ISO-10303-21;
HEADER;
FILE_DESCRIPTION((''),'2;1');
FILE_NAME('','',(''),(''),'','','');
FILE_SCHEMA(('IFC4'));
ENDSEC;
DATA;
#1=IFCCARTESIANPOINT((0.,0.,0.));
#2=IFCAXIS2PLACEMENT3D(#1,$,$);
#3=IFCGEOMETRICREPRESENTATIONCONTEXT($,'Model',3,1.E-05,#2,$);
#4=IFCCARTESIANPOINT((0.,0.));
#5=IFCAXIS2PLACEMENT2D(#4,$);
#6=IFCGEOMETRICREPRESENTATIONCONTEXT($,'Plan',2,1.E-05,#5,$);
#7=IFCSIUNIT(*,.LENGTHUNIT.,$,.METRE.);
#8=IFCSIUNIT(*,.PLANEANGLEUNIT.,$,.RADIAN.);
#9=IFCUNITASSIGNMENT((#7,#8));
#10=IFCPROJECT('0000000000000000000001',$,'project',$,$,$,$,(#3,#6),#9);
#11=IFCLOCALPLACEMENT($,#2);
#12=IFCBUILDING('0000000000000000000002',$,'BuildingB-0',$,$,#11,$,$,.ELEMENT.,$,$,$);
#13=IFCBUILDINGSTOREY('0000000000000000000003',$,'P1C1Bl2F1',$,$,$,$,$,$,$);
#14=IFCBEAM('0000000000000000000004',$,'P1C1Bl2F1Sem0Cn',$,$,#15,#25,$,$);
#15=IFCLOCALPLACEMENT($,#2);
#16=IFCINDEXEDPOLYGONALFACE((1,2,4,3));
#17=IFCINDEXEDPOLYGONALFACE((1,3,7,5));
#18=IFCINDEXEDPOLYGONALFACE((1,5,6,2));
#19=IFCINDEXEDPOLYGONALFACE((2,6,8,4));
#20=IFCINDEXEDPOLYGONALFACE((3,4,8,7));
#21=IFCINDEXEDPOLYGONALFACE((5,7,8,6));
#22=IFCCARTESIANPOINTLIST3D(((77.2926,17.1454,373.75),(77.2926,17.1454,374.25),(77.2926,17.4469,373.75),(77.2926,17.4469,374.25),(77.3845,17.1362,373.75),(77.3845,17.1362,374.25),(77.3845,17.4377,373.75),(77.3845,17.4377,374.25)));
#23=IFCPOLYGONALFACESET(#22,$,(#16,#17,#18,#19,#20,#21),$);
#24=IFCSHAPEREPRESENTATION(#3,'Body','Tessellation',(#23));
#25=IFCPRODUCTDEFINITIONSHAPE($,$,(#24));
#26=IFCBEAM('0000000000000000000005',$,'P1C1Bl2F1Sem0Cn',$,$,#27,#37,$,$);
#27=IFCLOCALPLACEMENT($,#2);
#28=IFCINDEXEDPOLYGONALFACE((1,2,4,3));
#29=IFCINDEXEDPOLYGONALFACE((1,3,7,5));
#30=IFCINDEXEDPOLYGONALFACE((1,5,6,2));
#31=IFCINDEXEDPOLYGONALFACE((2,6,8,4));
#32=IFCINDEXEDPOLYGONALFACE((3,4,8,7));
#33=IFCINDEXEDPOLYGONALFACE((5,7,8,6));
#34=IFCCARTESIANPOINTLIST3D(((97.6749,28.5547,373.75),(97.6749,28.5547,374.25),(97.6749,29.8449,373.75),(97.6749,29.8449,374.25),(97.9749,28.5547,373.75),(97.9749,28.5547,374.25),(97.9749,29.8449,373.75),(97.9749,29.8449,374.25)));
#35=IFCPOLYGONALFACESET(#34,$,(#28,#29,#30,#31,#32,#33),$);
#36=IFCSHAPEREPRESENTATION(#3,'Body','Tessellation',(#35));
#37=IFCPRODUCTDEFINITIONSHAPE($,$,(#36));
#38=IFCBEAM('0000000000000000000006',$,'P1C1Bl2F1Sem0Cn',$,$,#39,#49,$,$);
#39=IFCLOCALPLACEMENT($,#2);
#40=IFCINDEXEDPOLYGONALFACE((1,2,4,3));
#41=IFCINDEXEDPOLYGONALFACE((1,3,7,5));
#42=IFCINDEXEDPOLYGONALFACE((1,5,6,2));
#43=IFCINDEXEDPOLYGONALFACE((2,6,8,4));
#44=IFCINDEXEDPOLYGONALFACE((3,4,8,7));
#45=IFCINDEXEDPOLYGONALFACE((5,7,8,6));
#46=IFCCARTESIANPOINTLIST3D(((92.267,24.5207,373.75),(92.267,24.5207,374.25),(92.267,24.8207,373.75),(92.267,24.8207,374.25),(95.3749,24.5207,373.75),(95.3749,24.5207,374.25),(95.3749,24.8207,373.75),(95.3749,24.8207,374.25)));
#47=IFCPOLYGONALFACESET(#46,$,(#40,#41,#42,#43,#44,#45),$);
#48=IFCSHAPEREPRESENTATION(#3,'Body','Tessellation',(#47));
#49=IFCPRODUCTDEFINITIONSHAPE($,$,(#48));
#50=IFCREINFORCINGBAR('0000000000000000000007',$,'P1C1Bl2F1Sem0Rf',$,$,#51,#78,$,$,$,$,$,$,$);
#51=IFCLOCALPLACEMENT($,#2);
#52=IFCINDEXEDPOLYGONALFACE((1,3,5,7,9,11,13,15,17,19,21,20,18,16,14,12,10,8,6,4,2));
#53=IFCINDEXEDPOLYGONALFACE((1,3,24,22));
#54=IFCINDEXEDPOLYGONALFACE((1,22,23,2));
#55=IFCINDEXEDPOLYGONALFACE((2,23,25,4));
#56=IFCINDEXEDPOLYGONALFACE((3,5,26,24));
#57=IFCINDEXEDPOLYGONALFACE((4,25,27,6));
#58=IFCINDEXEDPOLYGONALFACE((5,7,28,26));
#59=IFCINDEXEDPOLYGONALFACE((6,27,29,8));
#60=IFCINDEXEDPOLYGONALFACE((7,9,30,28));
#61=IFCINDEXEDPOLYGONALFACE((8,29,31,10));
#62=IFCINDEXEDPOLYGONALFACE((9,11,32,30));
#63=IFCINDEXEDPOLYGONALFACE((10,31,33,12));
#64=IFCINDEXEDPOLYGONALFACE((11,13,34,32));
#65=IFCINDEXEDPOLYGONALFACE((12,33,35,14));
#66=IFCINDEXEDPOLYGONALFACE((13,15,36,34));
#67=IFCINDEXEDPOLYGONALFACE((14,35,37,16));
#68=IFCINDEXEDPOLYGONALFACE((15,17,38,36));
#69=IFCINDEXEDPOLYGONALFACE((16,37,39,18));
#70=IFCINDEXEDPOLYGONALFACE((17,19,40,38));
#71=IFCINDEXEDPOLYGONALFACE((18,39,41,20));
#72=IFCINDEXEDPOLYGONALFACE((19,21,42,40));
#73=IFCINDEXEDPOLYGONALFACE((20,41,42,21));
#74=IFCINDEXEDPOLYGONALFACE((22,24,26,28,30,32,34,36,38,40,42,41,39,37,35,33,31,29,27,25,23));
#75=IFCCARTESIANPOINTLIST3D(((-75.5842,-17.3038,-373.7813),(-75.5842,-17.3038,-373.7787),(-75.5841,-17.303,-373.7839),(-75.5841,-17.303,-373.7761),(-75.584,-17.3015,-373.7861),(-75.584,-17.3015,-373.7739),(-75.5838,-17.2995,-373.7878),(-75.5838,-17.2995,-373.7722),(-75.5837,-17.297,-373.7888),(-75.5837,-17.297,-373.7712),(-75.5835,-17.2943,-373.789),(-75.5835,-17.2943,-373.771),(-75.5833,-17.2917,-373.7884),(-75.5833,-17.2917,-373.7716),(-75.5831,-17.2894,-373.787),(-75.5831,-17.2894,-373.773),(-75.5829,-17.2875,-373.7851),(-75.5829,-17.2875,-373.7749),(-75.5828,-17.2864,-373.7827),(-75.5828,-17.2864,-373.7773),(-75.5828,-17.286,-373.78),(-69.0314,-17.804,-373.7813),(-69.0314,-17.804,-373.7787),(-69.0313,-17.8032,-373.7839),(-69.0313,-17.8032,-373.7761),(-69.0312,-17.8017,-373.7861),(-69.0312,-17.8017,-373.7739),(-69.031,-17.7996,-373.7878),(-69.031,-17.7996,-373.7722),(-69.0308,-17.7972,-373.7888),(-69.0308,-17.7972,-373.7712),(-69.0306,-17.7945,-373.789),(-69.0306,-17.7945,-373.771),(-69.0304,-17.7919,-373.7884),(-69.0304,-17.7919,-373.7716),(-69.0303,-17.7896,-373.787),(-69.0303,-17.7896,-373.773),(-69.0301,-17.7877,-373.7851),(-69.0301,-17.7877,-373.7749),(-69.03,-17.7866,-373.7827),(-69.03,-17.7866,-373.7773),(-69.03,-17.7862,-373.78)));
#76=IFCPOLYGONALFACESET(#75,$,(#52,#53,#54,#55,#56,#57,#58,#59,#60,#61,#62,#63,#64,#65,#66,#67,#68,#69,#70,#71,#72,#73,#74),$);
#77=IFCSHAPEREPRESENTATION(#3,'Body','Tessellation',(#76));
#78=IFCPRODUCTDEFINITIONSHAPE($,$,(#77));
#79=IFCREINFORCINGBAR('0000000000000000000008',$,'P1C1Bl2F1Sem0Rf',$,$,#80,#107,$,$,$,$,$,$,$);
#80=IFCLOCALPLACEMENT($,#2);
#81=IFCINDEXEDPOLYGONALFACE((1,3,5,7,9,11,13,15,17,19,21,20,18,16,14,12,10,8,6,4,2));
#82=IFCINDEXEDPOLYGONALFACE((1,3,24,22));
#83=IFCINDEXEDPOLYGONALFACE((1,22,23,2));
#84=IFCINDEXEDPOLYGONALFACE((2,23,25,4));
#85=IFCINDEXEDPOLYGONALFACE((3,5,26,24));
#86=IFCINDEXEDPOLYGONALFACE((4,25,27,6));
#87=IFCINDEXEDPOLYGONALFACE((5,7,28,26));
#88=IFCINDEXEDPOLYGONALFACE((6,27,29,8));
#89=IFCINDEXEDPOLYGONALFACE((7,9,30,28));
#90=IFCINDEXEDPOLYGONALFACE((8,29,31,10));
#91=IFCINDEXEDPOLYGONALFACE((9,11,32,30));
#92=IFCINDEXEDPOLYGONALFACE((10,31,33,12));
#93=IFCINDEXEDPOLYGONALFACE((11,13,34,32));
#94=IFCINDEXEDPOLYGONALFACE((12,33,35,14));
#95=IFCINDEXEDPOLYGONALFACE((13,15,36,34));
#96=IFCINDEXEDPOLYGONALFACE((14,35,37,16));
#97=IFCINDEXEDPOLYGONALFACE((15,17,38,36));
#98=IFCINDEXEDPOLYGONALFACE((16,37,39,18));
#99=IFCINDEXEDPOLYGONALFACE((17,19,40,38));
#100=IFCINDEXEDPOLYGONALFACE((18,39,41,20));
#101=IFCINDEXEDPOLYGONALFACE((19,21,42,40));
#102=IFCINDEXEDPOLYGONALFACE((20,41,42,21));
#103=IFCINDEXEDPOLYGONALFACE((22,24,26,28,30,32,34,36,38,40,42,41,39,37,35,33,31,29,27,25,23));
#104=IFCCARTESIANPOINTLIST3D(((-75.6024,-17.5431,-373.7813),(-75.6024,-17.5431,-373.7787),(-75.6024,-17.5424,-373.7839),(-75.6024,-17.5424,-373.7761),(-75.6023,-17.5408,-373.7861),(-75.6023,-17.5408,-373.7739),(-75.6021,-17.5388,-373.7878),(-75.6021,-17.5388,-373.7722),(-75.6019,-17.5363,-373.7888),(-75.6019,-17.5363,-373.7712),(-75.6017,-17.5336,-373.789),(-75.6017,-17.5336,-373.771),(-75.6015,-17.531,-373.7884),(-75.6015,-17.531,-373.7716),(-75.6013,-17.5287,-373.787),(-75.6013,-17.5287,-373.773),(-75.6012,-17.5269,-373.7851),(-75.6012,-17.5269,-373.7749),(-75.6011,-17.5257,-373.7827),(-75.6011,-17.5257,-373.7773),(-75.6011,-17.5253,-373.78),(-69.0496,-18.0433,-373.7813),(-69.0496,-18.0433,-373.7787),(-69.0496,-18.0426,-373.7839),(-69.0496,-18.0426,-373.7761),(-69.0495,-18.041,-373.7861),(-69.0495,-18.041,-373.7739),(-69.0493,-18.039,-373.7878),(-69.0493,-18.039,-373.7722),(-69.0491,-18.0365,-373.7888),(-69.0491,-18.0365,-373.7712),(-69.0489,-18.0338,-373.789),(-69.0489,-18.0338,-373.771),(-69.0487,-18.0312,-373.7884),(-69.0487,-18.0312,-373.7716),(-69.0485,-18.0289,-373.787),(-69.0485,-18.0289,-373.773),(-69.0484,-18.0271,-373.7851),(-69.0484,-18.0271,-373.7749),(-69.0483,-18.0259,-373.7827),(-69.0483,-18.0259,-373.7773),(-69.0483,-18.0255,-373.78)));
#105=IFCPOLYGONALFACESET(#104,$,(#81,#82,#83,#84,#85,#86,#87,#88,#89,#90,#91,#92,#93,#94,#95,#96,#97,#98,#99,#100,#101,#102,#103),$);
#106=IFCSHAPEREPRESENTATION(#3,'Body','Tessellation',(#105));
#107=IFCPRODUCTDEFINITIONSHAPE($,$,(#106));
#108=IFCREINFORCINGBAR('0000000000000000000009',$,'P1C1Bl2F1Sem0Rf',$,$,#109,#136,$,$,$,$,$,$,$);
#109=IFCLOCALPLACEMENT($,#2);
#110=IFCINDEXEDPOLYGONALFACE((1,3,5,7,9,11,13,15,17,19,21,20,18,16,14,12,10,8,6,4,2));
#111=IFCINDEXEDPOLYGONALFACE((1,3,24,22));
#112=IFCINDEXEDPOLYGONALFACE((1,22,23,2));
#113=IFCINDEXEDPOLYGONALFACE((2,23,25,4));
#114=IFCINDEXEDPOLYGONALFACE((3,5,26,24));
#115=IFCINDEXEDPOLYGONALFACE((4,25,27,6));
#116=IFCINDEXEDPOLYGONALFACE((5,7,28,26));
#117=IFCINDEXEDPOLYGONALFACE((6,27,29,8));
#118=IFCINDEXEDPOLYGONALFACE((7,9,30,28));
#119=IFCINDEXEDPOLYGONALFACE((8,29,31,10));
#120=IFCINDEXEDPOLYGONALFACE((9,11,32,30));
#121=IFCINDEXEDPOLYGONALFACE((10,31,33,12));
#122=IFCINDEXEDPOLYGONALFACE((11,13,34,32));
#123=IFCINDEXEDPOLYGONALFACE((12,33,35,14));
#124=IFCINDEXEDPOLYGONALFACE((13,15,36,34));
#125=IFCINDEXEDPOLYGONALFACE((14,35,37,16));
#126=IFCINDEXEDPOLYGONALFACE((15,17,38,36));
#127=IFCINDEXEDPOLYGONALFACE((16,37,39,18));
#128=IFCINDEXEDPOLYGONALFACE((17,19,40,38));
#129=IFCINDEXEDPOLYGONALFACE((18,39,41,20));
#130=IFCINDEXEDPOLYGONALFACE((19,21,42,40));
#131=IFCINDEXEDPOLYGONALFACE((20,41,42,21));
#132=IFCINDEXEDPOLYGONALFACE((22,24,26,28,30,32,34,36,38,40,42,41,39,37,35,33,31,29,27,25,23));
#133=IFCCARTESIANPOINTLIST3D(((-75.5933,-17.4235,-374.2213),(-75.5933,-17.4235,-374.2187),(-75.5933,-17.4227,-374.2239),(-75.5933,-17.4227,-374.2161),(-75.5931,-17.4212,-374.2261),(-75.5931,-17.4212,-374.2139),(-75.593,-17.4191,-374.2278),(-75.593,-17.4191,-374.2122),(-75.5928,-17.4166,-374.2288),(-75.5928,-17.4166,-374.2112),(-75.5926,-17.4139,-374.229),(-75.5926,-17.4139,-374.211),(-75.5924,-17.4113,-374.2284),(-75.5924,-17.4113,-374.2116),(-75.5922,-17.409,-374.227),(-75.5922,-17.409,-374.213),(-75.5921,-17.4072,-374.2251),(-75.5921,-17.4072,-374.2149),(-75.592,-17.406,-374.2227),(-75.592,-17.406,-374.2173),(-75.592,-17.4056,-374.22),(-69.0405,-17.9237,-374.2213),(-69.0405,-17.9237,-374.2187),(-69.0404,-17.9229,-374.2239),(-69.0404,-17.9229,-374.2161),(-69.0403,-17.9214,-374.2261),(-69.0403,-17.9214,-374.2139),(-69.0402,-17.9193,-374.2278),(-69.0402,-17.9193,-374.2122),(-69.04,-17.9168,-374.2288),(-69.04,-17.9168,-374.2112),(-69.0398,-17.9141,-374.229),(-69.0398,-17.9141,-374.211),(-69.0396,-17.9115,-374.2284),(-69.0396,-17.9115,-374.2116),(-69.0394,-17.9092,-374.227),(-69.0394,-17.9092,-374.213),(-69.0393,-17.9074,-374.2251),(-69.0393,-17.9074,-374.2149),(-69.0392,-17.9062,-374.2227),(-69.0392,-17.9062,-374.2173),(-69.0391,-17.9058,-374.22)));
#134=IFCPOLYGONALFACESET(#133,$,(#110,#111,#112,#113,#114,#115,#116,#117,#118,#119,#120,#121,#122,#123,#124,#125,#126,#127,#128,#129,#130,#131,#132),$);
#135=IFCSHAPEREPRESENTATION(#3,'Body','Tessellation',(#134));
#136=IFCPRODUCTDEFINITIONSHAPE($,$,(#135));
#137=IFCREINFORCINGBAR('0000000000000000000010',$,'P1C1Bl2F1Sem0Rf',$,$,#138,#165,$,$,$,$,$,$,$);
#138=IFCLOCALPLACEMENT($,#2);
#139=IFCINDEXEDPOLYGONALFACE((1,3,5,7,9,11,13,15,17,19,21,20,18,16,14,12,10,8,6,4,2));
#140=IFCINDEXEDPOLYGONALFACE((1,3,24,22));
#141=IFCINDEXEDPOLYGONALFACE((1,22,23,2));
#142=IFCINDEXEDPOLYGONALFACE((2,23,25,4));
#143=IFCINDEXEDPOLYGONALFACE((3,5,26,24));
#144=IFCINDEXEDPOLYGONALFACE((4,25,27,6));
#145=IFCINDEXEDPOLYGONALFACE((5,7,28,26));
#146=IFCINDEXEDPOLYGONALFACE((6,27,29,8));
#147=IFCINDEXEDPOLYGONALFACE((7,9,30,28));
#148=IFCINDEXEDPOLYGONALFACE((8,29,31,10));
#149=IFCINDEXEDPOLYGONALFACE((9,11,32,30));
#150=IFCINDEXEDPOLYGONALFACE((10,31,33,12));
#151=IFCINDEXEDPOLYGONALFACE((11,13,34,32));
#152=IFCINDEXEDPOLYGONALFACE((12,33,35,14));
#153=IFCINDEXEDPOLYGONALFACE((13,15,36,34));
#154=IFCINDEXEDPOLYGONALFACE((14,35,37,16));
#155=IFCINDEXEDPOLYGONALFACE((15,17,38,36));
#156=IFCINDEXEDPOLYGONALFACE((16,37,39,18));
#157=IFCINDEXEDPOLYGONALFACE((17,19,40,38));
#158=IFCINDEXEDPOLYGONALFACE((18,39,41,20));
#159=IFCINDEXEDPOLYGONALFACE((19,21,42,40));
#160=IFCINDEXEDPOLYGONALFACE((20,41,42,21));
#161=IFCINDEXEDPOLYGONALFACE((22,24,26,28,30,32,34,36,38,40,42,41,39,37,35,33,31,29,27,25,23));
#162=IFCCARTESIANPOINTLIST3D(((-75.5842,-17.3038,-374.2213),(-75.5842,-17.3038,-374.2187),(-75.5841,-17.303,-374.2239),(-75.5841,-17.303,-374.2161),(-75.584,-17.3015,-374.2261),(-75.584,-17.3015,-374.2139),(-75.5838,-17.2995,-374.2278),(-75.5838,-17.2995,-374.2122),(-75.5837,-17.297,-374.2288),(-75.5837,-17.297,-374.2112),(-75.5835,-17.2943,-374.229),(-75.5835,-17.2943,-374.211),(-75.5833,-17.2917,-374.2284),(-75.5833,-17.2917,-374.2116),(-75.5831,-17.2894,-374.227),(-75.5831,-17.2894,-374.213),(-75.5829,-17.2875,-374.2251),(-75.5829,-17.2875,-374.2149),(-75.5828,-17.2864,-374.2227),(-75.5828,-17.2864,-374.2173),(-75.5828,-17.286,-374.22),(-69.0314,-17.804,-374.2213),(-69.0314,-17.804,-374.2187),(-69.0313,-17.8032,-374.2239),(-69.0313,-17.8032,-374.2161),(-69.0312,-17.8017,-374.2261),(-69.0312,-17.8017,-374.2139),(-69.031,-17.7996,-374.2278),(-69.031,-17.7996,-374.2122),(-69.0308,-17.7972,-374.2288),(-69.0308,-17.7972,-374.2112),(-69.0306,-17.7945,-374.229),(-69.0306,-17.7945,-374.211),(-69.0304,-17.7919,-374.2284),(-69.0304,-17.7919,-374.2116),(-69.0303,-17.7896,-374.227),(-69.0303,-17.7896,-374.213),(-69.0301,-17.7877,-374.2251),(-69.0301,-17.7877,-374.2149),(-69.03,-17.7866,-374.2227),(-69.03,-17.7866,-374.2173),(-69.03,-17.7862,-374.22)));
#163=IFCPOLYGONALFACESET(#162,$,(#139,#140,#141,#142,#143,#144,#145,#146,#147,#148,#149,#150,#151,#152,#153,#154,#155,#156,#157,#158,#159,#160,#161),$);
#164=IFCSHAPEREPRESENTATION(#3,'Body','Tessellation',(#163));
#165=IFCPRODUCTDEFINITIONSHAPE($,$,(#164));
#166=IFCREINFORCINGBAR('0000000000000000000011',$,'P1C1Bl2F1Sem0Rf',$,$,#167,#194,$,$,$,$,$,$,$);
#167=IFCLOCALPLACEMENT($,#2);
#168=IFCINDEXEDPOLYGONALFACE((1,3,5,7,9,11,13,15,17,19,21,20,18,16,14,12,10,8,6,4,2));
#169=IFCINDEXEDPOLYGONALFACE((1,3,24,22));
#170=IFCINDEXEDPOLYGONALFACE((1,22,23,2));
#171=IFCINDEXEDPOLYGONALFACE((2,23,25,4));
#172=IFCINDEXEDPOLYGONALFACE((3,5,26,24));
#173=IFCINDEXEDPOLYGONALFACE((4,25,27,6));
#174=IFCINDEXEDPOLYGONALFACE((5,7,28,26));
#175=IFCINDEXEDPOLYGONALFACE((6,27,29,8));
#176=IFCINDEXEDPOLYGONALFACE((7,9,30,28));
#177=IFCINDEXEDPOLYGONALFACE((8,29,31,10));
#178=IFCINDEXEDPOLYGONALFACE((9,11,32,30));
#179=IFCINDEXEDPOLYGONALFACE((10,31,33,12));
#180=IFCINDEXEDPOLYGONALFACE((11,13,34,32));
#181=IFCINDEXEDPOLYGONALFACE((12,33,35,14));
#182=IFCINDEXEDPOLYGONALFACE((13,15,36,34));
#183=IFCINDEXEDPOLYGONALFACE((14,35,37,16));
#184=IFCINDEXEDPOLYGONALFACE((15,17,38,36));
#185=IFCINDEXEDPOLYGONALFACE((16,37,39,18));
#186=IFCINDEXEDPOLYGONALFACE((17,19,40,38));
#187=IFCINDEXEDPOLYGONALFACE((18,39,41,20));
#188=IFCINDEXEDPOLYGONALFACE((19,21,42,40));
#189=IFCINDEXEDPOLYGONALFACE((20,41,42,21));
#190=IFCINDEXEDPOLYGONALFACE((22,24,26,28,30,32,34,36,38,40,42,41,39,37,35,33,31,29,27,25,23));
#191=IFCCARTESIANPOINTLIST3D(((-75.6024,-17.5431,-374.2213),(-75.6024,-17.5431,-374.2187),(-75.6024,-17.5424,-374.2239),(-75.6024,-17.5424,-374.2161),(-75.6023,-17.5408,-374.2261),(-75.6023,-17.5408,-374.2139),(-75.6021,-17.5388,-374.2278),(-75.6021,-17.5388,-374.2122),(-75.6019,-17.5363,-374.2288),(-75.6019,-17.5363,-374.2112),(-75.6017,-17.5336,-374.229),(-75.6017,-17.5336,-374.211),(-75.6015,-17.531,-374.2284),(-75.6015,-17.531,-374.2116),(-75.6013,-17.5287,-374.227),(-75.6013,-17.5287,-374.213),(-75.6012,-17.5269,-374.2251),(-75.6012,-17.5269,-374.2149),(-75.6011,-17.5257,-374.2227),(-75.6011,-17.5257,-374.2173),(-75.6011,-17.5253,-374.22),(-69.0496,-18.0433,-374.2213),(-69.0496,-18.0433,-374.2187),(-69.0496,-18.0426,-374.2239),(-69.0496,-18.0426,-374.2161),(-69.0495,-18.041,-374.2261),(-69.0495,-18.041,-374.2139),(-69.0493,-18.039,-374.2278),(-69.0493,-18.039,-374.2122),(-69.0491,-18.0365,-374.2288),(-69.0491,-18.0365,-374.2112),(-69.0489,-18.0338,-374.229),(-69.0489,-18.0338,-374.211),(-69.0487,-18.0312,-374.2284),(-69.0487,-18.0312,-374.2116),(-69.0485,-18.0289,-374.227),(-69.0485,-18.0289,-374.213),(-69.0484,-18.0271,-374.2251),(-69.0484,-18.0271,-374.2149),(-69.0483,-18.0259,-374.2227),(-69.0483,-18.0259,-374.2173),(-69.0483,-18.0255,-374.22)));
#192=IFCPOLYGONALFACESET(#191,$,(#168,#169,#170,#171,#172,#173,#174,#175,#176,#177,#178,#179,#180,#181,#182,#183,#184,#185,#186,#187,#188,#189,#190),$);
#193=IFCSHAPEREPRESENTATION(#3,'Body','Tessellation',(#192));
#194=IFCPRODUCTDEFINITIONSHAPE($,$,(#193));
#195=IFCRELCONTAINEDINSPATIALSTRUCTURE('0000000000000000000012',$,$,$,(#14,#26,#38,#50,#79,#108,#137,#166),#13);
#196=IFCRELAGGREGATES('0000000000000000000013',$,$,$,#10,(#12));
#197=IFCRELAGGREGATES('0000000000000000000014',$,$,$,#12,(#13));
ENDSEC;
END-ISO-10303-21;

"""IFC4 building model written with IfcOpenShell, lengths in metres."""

from ifc_helpers import new_model, entity, si_unit, origin, origin_2d, place, context, project, spatial, polyline, outline, extrude, element, save


model = new_model("IFC4")

# Units and contexts
model_context = context("Model", 3, precision=1e-05, world=origin())
plan_context = context("Plan", 2, precision=1e-05, world=origin_2d())
ifc_project = project(units=[si_unit("LENGTHUNIT", "METRE"), si_unit("PLANEANGLEUNIT", "RADIAN")], contexts=[model_context, plan_context])

# Building, storey
building_placement = place(None, origin())
building = spatial("IfcBuilding", under=ifc_project, at=building_placement, Name="BuildingB-0", CompositionType="ELEMENT")
storey = spatial("IfcBuildingStorey", under=building, Name="P1C1Bl2F1")

# Beams
element("IfcBeam", 1, inside=storey, Name="P1C1Bl2F1Sem0Cn", context=model_context, shape_type="SweptSolid", body=[
    extrude(outline(polyline([(77.3845, 17.1362, 373.75), (77.2926, 17.1454, 373.75), (77.2926, 17.4469, 373.75), (77.3845, 17.4377, 373.75), (77.3845, 17.1362, 373.75)])), None, (0.0, 0.0, 1.0), 0.5),
])
element("IfcBeam", 2, inside=storey, Name="P1C1Bl2F1Sem0Cn", context=model_context, shape_type="SweptSolid", body=[
    extrude(outline(polyline([(97.9749, 28.5547, 373.75), (97.6749, 28.5547, 373.75), (97.6749, 29.8449, 373.75), (97.9749, 29.8449, 373.75), (97.9749, 28.5547, 373.75)])), None, (0.0, 0.0, 1.0), 0.5),
])
element("IfcBeam", 3, inside=storey, Name="P1C1Bl2F1Sem0Cn", context=model_context, shape_type="SweptSolid", body=[
    extrude(outline(polyline([(95.3749, 24.5207, 373.75), (95.3749, 24.8207, 373.75), (92.267, 24.8207, 373.75), (92.267, 24.5207, 373.75), (95.3749, 24.5207, 373.75)])), None, (0.0, 0.0, 1.0), 0.5),
])

# Reinforcing bars
element("IfcReinforcingBar", 4, inside=storey, Name="P1C1Bl2F1Sem0Rf", context=model_context, shape_type="SweptSolid", body=[
    entity("IfcSurfaceCurveSweptAreaSolid", entity("IfcCircleProfileDef", "AREA", None, None, 0.009), None, entity("IfcPolyline", [entity("IfcCartesianPoint", [69.0307, 17.7952, 373.78]), entity("IfcCartesianPoint", [75.5835, 17.295, 373.78])]), None, None, entity("IfcPlane", entity("IfcAxis2Placement3D", entity("IfcCartesianPoint", [69.0307, 17.7952, 373.78]), entity("IfcDirection", [0.0, 0.0, 1.0]), entity("IfcDirection", [1.0, 0.0, 0.0])))),
])
element("IfcReinforcingBar", 5, inside=storey, Name="P1C1Bl2F1Sem0Rf", context=model_context, shape_type="SweptSolid", body=[
    entity("IfcSurfaceCurveSweptAreaSolid", entity("IfcCircleProfileDef", "AREA", None, None, 0.009), None, entity("IfcPolyline", [entity("IfcCartesianPoint", [69.049, 18.0345, 373.78]), entity("IfcCartesianPoint", [75.6018, 17.5343, 373.78])]), None, None, entity("IfcPlane", entity("IfcAxis2Placement3D", entity("IfcCartesianPoint", [69.049, 18.0345, 373.78]), entity("IfcDirection", [0.0, 0.0, 1.0]), entity("IfcDirection", [1.0, 0.0, 0.0])))),
])
element("IfcReinforcingBar", 6, inside=storey, Name="P1C1Bl2F1Sem0Rf", context=model_context, shape_type="SweptSolid", body=[
    entity("IfcSurfaceCurveSweptAreaSolid", entity("IfcCircleProfileDef", "AREA", None, None, 0.009), None, entity("IfcPolyline", [entity("IfcCartesianPoint", [69.0398, 17.9148, 374.22]), entity("IfcCartesianPoint", [75.5926, 17.4146, 374.22])]), None, None, entity("IfcPlane", entity("IfcAxis2Placement3D", entity("IfcCartesianPoint", [69.0398, 17.9148, 374.22]), entity("IfcDirection", [0.0, 0.0, 1.0]), entity("IfcDirection", [1.0, 0.0, 0.0])))),
])
element("IfcReinforcingBar", 7, inside=storey, Name="P1C1Bl2F1Sem0Rf", context=model_context, shape_type="SweptSolid", body=[
    entity("IfcSurfaceCurveSweptAreaSolid", entity("IfcCircleProfileDef", "AREA", None, None, 0.009), None, entity("IfcPolyline", [entity("IfcCartesianPoint", [69.0307, 17.7952, 374.22]), entity("IfcCartesianPoint", [75.5835, 17.295, 374.22])]), None, None, entity("IfcPlane", entity("IfcAxis2Placement3D", entity("IfcCartesianPoint", [69.0307, 17.7952, 374.22]), entity("IfcDirection", [0.0, 0.0, 1.0]), entity("IfcDirection", [1.0, 0.0, 0.0])))),
])
element("IfcReinforcingBar", 8, inside=storey, Name="P1C1Bl2F1Sem0Rf", context=model_context, shape_type="SweptSolid", body=[
    entity("IfcSurfaceCurveSweptAreaSolid", entity("IfcCircleProfileDef", "AREA", None, None, 0.009), None, entity("IfcPolyline", [entity("IfcCartesianPoint", [69.049, 18.0345, 374.22]), entity("IfcCartesianPoint", [75.6018, 17.5343, 374.22])]), None, None, entity("IfcPlane", entity("IfcAxis2Placement3D", entity("IfcCartesianPoint", [69.049, 18.0345, 374.22]), entity("IfcDirection", [0.0, 0.0, 1.0]), entity("IfcDirection", [1.0, 0.0, 0.0])))),
])

save(model, "model.ifc")
